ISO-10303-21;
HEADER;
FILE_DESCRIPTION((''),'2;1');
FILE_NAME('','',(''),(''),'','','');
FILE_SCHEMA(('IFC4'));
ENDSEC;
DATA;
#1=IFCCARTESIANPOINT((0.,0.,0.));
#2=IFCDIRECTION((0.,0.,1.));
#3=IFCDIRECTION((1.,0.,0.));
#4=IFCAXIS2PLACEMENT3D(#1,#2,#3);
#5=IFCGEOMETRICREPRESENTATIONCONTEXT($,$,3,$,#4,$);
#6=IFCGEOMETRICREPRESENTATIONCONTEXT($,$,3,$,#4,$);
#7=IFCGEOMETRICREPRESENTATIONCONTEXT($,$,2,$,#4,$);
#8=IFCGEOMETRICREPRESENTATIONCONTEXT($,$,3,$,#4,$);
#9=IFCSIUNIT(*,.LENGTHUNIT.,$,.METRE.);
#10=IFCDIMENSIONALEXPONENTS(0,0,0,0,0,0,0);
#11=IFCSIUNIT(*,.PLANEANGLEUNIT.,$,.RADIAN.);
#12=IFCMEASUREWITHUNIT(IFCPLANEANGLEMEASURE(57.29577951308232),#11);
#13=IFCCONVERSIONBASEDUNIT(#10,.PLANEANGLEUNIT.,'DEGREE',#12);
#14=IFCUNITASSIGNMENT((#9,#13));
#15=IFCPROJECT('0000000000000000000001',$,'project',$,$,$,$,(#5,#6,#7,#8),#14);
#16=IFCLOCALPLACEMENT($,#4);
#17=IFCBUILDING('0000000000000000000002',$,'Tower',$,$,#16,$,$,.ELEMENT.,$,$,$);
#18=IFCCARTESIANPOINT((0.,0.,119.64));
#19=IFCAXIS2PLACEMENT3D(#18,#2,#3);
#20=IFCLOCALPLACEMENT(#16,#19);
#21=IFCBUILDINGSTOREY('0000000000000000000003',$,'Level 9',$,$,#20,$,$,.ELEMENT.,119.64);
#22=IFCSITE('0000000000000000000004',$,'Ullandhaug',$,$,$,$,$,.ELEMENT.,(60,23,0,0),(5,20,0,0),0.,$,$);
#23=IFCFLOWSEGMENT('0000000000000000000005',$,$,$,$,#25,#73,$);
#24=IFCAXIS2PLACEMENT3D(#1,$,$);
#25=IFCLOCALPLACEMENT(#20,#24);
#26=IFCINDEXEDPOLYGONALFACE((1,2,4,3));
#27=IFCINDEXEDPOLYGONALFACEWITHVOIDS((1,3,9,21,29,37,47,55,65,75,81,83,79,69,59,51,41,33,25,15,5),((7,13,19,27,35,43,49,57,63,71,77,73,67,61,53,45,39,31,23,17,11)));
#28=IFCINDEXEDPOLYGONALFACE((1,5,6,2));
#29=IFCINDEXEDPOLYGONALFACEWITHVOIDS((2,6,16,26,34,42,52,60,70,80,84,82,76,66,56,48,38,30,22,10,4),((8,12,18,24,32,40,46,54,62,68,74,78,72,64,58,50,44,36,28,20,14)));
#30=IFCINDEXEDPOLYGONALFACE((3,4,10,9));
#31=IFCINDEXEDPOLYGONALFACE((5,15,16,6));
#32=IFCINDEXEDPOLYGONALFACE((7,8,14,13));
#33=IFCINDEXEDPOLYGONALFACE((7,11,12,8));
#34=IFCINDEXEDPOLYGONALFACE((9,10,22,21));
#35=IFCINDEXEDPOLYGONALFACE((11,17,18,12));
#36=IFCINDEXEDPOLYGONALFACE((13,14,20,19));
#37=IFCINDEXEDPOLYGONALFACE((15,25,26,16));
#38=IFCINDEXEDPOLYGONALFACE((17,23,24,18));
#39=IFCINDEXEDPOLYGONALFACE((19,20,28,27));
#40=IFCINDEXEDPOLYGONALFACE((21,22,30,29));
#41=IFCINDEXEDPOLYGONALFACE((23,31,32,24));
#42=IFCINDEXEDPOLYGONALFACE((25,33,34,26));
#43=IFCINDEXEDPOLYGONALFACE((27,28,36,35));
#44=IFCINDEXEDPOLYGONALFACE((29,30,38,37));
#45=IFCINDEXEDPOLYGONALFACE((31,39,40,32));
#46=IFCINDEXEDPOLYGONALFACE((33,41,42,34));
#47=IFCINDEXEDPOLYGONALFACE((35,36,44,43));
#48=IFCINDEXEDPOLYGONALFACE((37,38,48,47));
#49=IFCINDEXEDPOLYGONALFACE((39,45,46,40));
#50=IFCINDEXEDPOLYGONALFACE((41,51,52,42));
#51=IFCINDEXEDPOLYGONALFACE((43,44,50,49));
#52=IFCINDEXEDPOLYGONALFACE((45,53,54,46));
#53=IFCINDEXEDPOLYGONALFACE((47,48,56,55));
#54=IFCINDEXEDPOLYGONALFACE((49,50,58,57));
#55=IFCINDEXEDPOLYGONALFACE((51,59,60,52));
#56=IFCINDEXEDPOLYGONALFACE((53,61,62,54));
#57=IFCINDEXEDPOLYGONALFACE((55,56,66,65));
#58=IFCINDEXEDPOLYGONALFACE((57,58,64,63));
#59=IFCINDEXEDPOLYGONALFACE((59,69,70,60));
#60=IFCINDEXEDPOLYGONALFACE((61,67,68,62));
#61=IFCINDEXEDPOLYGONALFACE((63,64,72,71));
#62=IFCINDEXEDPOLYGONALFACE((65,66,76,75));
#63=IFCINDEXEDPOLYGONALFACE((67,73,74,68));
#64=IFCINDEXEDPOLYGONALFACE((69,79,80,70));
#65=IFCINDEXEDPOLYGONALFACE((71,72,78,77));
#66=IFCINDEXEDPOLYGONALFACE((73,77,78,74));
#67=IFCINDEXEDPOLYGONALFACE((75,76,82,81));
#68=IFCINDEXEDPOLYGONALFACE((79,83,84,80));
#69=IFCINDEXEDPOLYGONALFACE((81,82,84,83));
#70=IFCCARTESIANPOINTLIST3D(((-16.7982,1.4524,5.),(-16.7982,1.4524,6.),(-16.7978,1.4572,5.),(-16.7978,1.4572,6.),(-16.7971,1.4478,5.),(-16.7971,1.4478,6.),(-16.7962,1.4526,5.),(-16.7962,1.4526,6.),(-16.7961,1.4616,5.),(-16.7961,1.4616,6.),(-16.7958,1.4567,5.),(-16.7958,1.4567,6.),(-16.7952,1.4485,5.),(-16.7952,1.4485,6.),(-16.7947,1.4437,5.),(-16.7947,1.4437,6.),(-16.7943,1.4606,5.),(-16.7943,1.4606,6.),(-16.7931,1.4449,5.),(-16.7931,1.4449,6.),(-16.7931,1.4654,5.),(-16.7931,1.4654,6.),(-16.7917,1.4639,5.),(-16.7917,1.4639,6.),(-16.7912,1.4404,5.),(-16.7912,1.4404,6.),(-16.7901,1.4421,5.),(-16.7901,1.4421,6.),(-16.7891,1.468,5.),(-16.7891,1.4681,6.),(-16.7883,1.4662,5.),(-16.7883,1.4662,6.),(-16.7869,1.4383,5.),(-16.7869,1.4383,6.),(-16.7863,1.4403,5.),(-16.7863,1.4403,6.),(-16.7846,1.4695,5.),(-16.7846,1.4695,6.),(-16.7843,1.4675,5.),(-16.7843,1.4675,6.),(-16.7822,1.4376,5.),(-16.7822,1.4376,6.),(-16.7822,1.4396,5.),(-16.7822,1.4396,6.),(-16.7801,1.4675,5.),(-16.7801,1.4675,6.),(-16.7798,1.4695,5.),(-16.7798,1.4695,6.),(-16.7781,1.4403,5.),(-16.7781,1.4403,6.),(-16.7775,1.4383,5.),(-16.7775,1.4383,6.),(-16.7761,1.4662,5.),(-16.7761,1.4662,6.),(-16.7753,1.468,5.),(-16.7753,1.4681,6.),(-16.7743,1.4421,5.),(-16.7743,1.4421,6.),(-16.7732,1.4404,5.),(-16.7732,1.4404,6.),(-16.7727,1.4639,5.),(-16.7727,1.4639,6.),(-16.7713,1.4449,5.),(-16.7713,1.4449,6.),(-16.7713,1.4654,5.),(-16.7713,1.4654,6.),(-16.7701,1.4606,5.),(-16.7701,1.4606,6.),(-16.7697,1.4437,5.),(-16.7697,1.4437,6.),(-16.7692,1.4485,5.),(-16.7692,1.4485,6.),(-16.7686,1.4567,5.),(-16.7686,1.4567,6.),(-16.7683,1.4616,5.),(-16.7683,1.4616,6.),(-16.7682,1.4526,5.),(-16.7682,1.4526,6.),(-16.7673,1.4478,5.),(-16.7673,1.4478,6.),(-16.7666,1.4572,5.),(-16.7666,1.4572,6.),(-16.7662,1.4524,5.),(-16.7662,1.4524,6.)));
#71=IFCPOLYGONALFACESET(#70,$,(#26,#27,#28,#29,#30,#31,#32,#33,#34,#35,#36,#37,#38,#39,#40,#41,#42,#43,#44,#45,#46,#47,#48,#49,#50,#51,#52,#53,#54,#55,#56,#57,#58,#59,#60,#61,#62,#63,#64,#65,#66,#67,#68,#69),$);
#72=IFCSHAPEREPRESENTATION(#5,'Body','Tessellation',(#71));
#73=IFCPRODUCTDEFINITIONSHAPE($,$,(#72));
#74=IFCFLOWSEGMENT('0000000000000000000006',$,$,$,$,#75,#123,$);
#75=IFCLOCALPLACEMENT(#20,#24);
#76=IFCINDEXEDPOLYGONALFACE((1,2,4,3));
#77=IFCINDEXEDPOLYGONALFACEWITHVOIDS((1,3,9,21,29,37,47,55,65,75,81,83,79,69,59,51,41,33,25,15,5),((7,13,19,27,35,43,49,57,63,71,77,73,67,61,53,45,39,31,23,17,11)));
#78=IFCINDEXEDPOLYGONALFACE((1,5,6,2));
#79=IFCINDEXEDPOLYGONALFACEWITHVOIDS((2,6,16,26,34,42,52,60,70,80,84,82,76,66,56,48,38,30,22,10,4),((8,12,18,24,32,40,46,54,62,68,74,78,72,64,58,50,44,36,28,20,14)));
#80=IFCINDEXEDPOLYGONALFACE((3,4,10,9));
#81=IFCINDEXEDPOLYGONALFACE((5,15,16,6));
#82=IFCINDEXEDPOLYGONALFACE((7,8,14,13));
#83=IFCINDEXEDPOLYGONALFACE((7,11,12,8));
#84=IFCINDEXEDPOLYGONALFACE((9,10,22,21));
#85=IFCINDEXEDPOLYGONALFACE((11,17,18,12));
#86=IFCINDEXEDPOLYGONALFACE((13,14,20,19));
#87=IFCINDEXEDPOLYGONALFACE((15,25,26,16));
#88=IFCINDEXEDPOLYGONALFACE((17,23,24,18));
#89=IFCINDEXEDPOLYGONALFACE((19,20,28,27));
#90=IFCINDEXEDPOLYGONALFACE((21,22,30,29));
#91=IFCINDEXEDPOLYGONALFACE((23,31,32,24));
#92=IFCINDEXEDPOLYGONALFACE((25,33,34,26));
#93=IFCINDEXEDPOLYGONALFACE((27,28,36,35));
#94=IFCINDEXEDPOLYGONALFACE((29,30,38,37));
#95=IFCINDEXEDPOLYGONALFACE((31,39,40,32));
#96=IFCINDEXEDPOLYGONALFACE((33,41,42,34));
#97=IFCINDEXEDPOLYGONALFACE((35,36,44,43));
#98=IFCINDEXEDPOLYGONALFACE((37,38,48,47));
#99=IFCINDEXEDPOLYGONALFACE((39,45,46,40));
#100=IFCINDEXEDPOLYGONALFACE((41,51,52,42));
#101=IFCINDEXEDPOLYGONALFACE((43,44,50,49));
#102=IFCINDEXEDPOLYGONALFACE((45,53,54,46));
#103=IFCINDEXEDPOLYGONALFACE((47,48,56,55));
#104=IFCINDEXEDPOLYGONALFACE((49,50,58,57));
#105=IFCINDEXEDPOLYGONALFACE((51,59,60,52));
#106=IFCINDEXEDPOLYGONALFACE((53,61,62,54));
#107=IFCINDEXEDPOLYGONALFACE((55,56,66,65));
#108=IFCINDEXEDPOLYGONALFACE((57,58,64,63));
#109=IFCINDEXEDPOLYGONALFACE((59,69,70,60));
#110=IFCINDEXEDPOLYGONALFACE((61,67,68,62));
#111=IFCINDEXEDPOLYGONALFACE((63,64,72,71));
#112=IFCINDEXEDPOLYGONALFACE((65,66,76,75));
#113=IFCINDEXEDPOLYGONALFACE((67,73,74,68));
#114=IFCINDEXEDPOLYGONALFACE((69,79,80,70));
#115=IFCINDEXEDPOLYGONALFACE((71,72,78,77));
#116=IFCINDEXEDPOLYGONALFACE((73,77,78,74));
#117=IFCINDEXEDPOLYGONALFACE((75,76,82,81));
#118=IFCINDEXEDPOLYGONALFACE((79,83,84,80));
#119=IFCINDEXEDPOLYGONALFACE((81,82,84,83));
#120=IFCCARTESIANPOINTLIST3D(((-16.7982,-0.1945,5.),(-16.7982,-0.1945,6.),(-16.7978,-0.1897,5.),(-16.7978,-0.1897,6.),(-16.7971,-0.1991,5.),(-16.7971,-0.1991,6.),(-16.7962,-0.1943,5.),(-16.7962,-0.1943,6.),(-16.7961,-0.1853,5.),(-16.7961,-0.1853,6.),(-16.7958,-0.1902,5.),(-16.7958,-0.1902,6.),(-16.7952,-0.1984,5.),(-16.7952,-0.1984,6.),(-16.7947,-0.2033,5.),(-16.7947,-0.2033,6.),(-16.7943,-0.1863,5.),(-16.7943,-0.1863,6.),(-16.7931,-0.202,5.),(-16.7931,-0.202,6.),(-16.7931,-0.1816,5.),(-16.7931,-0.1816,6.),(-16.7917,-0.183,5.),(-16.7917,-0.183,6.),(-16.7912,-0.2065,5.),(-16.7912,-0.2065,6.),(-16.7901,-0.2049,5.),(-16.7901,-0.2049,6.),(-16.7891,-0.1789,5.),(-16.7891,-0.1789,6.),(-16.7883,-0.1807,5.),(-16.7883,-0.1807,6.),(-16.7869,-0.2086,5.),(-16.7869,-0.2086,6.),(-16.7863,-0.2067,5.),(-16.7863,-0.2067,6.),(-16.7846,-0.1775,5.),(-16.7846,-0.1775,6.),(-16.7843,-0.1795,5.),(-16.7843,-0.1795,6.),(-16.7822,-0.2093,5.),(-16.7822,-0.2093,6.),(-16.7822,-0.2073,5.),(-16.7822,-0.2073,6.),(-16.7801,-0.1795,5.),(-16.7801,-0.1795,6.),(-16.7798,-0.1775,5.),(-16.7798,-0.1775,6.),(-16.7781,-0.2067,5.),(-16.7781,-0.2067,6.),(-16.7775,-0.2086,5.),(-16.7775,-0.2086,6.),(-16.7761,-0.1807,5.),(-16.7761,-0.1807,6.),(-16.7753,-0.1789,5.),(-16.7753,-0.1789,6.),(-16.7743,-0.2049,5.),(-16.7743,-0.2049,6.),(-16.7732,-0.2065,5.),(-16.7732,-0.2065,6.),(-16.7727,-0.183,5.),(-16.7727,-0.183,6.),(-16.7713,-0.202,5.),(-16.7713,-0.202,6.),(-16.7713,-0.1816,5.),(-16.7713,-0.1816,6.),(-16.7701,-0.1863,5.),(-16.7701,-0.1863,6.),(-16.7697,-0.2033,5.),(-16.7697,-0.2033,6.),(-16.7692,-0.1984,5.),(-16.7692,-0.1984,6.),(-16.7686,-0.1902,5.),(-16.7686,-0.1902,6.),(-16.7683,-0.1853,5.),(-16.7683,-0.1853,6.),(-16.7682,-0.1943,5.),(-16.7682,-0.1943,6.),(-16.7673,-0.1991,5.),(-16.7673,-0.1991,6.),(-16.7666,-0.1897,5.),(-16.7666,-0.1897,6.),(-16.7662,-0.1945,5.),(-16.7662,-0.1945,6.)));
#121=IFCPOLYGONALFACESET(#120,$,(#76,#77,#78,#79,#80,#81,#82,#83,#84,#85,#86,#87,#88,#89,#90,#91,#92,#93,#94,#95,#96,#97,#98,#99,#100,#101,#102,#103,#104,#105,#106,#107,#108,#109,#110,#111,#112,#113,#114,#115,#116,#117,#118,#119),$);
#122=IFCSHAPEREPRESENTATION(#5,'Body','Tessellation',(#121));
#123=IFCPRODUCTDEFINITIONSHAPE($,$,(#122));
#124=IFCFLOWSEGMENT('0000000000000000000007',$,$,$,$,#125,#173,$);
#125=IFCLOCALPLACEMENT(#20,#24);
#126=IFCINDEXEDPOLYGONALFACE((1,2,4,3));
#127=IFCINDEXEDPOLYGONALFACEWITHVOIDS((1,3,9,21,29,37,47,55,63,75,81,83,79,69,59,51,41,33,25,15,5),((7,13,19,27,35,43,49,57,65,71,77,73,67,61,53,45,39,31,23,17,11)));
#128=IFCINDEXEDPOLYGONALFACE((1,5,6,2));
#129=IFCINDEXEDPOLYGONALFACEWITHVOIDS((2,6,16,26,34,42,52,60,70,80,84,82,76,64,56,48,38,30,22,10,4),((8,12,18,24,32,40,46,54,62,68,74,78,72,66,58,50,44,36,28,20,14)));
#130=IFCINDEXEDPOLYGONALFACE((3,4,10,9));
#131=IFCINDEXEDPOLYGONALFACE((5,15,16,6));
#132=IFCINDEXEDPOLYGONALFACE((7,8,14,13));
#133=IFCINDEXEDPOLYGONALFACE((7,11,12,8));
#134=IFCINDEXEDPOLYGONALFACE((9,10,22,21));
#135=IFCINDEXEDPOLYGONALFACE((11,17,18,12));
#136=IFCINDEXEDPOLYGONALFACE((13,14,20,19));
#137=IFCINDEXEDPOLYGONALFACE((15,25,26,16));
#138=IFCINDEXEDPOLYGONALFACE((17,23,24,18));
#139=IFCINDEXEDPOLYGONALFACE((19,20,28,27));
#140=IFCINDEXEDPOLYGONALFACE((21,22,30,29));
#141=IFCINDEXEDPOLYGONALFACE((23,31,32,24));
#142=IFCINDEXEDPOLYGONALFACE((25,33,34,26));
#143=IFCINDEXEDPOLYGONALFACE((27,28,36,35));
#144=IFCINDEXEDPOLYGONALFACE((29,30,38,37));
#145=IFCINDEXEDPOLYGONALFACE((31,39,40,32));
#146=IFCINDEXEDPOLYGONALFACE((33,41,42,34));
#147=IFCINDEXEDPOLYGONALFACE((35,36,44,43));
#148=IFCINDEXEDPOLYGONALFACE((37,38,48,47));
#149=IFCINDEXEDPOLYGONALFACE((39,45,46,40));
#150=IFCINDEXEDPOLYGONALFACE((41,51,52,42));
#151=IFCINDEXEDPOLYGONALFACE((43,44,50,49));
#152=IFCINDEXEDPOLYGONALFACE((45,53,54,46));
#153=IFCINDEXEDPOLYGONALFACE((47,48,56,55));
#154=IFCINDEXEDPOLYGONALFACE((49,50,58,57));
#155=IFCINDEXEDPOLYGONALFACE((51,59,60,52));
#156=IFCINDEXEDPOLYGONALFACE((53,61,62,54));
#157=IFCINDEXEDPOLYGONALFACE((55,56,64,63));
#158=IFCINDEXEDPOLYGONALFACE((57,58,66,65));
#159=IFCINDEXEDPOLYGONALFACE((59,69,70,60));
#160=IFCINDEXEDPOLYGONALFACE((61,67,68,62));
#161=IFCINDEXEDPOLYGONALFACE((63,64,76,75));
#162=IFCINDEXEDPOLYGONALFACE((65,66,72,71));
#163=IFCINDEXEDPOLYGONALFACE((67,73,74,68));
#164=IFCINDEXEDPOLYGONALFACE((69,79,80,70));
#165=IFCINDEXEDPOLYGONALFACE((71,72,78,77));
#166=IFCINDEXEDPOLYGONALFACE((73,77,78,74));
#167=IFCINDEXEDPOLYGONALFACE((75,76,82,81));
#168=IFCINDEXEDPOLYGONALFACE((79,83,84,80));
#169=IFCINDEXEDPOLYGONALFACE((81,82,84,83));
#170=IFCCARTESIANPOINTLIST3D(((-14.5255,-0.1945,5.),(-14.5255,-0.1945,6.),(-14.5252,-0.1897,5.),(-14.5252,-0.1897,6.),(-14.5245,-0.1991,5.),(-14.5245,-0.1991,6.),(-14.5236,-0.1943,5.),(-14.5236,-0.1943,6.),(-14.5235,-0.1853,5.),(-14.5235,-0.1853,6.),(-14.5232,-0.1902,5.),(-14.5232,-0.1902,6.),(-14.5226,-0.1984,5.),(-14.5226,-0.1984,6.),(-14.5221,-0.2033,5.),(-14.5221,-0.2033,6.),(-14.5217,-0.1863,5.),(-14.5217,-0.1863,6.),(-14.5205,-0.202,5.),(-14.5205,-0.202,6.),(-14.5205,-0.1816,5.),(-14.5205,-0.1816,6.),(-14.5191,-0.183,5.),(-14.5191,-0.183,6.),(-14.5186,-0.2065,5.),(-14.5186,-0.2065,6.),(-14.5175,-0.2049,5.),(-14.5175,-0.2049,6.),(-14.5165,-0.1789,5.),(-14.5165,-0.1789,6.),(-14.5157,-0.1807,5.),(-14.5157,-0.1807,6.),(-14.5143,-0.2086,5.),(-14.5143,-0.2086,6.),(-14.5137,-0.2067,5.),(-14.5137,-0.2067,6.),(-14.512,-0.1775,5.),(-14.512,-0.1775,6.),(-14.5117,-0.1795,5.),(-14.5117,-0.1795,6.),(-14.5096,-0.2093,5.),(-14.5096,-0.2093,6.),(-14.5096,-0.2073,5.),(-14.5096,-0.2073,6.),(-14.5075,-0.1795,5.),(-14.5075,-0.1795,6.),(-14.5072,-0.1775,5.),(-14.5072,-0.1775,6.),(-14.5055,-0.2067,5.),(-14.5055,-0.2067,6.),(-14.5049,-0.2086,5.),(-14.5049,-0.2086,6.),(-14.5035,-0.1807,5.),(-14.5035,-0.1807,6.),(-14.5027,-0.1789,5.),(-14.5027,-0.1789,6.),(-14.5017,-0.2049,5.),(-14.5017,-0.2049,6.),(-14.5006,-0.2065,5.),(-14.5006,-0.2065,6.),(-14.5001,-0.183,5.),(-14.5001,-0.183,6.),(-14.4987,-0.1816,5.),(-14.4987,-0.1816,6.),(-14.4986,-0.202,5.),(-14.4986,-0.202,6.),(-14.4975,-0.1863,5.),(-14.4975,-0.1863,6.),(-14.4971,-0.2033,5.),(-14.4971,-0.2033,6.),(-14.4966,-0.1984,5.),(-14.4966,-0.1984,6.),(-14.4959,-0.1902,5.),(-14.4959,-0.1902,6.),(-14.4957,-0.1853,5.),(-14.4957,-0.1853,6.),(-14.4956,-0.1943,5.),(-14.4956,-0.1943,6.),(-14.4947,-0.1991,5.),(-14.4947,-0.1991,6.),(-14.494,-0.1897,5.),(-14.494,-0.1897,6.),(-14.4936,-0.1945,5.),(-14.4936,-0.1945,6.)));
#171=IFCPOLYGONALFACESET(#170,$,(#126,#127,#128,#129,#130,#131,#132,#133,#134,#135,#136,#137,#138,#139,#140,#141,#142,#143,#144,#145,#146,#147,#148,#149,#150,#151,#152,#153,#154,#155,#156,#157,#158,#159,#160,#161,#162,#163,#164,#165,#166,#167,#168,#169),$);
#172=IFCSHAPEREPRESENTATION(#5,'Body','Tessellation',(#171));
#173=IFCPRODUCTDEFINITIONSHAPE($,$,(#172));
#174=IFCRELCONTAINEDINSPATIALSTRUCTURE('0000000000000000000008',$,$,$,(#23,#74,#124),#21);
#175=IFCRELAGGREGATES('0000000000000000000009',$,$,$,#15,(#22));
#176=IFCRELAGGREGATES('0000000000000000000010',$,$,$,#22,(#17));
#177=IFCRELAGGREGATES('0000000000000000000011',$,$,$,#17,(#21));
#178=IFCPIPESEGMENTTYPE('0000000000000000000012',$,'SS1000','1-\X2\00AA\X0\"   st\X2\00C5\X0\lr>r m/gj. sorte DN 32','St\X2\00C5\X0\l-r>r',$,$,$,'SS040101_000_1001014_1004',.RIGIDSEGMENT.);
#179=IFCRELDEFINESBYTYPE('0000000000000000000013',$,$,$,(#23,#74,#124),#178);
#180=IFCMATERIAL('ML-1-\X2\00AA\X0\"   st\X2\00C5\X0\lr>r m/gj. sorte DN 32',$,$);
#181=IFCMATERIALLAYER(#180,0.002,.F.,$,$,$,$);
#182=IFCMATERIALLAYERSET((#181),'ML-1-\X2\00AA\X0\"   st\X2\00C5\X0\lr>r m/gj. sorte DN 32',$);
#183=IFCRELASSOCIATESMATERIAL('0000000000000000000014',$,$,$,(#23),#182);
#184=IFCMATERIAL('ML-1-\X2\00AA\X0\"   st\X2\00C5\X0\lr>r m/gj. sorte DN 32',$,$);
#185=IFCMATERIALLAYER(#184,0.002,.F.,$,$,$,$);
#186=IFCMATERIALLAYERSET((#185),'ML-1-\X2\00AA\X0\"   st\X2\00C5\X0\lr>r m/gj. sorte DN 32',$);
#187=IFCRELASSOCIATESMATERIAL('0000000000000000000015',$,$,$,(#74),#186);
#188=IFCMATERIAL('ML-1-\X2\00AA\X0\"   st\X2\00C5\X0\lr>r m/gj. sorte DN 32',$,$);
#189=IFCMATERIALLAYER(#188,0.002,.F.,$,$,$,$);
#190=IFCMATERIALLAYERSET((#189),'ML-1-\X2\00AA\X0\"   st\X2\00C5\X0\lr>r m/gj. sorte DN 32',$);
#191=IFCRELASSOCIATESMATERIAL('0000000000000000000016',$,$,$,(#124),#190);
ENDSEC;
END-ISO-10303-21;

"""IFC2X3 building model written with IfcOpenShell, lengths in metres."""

from ifc_helpers import new_model, entity, si_unit, converted_unit, frame, origin_with_axes, origin_2d_with_axis, place, context, project, spatial, hollow_circle, extrude, material, layer, layer_set, layer_usage, type_object, element, save


model = new_model("IFC2X3")

# Units and contexts
context_of_model_1 = context(None, 3, world=origin_with_axes())
context_of_model_2 = context(None, 3, world=origin_with_axes())
context_of_model_3 = context(None, 2, world=origin_with_axes())
context_of_model_4 = context(None, 3, world=origin_with_axes())
ifc_project = project(units=[si_unit("LENGTHUNIT", "METRE"), converted_unit("PLANEANGLEUNIT", "DEGREE", entity("IfcPlaneAngleMeasure", 57.29577951308232), si_unit("PLANEANGLEUNIT", "RADIAN"), dimensions=[0, 0, 0, 0, 0, 0, 0])], contexts=[context_of_model_1, context_of_model_2, context_of_model_3, context_of_model_4])

# Site, building, storey
site = spatial("IfcSite", under=ifc_project, Name="Ullandhaug", CompositionType="ELEMENT", RefLatitude=(60, 23, 0, 0), RefLongitude=(5, 20, 0, 0), RefElevation=0.0)
building_placement = place(None, origin_with_axes())
building = spatial("IfcBuilding", under=site, at=building_placement, Name="Tower", CompositionType="ELEMENT")
storey_placement = place(building_placement, frame((0.0, 0.0, 119.64), z_axis=(0.0, 0.0, 1.0), x_axis=(1.0, 0.0, 0.0)))
storey = spatial("IfcBuildingStorey", under=building, at=storey_placement, Name="Level 9", CompositionType="ELEMENT", Elevation=119.64)

# Flow segments
pipe_segment_type_1 = type_object("IfcPipeSegmentType", Name="SS1000", Description="1-ª\"   stÅlr>r m/gj. sorte DN 32", ApplicableOccurrence="StÅl-r>r", ElementType="SS040101_000_1001014_1004", PredefinedType="RIGIDSEGMENT")
ifc_material_1 = material(Name="ML-1-ª\"   stÅlr>r m/gj. sorte DN 32")
ifc_layer_1 = layer(ifc_material_1, 0.002, ventilated=False)
ifc_layer_set_1 = layer_set([ifc_layer_1], Name="ML-1-ª\"   stÅlr>r m/gj. sorte DN 32")
ifc_layer_usage_1 = layer_usage(ifc_layer_set_1, "AXIS2", "POSITIVE", 0.0)
flow_segment_1_placement = place(storey_placement, frame((-16.7822, 1.4536, 5.0), z_axis=(0.0, 0.0, 1.0), x_axis=(0.0, -1.0, 0.0)))
element("IfcFlowSegment", 1, at=flow_segment_1_placement, inside=storey, type_object=pipe_segment_type_1, material=ifc_layer_usage_1, context=context_of_model_1, shape_type="SweptSolid", body=[
    extrude(hollow_circle(Radius=0.016, WallThickness=0.002, at=origin_2d_with_axis()), origin_with_axes(), (0.0, 0.0, 1.0), 1.0),
])
ifc_material_2 = material(Name="ML-1-ª\"   stÅlr>r m/gj. sorte DN 32")
ifc_layer_2 = layer(ifc_material_2, 0.002, ventilated=False)
ifc_layer_set_2 = layer_set([ifc_layer_2], Name="ML-1-ª\"   stÅlr>r m/gj. sorte DN 32")
ifc_layer_usage_2 = layer_usage(ifc_layer_set_2, "AXIS2", "POSITIVE", 0.0)
flow_segment_2_placement = place(storey_placement, frame((-16.7822, -0.1933, 5.0), z_axis=(0.0, 0.0, 1.0), x_axis=(0.0, -1.0, 0.0)))
element("IfcFlowSegment", 2, at=flow_segment_2_placement, inside=storey, type_object=pipe_segment_type_1, material=ifc_layer_usage_2, context=context_of_model_1, shape_type="SweptSolid", body=[
    extrude(hollow_circle(Radius=0.016, WallThickness=0.002, at=origin_2d_with_axis()), origin_with_axes(), (0.0, 0.0, 1.0), 1.0),
])
ifc_material_3 = material(Name="ML-1-ª\"   stÅlr>r m/gj. sorte DN 32")
ifc_layer_3 = layer(ifc_material_3, 0.002, ventilated=False)
ifc_layer_set_3 = layer_set([ifc_layer_3], Name="ML-1-ª\"   stÅlr>r m/gj. sorte DN 32")
ifc_layer_usage_3 = layer_usage(ifc_layer_set_3, "AXIS2", "POSITIVE", 0.0)
flow_segment_3_placement = place(storey_placement, frame((-14.5096, -0.1933, 5.0), z_axis=(0.0, 0.0, 1.0), x_axis=(0.0, -1.0, 0.0)))
element("IfcFlowSegment", 3, at=flow_segment_3_placement, inside=storey, type_object=pipe_segment_type_1, material=ifc_layer_usage_3, context=context_of_model_1, shape_type="SweptSolid", body=[
    extrude(hollow_circle(Radius=0.016, WallThickness=0.002, at=origin_2d_with_axis()), origin_with_axes(), (0.0, 0.0, 1.0), 1.0),
])

save(model, "model.ifc")
